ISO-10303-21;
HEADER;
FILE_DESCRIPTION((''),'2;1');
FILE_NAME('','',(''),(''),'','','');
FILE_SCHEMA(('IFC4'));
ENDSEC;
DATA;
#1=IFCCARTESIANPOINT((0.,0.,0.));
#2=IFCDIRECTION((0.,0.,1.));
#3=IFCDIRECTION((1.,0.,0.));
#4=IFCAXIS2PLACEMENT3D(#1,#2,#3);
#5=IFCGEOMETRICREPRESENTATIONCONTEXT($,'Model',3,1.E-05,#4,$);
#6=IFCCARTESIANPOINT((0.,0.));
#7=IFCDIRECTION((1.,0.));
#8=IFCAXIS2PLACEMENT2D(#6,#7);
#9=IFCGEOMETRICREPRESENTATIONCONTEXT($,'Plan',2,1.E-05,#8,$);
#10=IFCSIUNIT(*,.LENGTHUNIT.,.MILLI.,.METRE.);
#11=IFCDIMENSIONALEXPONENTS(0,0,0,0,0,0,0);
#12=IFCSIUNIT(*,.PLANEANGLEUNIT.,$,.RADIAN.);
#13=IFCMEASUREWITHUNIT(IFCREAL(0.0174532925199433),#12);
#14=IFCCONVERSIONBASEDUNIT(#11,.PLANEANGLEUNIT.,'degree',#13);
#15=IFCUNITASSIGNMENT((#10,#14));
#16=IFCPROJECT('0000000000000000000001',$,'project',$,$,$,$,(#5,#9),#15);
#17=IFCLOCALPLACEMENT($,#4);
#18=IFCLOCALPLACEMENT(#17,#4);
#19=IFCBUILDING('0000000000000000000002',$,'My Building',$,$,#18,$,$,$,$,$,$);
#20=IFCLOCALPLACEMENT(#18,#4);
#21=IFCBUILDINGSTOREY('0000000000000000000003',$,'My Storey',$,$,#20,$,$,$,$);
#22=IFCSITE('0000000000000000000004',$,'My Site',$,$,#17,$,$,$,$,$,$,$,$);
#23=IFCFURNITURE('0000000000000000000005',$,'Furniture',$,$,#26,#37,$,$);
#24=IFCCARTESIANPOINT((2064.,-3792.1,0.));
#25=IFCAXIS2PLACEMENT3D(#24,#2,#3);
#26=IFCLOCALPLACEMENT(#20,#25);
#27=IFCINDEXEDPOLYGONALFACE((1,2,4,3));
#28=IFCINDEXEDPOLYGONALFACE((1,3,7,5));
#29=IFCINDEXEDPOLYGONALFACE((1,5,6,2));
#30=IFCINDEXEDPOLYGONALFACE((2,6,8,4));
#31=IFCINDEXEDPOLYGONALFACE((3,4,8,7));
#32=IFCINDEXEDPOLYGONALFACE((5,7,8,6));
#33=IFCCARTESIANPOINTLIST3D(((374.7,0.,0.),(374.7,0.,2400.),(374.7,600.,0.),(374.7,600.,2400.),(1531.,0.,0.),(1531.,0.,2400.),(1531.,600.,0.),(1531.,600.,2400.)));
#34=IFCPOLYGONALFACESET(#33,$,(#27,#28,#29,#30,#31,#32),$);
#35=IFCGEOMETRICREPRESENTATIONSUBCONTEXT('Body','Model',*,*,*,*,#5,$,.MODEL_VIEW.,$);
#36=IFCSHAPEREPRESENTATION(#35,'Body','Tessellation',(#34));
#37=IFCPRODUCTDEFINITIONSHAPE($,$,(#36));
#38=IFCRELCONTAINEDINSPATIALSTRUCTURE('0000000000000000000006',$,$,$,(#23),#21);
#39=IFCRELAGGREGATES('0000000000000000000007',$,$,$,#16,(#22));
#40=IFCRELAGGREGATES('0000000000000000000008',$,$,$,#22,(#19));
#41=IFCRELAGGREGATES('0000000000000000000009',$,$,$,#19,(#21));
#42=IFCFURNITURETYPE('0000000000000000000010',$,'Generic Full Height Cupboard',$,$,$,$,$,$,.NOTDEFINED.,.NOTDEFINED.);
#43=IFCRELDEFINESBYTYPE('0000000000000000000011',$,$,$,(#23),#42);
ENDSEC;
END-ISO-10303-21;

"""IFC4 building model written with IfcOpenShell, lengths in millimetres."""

from ifc_helpers import new_model, entity, si_unit, converted_unit, frame, origin_with_axes, origin_2d_with_axis, place, context, subcontext, project, spatial, indexed_curve, outline, extrude, shape, source, transform, mapped, type_object, type_shapes, element, save


model = new_model("IFC4")

# Units and contexts
model_context = context("Model", 3, precision=1e-05, world=origin_with_axes())
plan_context = context("Plan", 2, precision=1e-05, world=origin_2d_with_axis())
body_context_1 = subcontext(model_context, "Body", "Model", "MODEL_VIEW")
body_context_2 = subcontext(plan_context, "Body", "Plan", "PLAN_VIEW")
ifc_project = project(units=[si_unit("LENGTHUNIT", "METRE", prefix="MILLI"), converted_unit("PLANEANGLEUNIT", "degree", entity("IfcReal", 0.0174532925199433), si_unit("PLANEANGLEUNIT", "RADIAN"), dimensions=[0, 0, 0, 0, 0, 0, 0])], contexts=[model_context, plan_context])

# Site, building, storey
site_placement = place(None, origin_with_axes())
site = spatial("IfcSite", under=ifc_project, at=site_placement, Name="My Site")
building_placement = place(site_placement, origin_with_axes())
building = spatial("IfcBuilding", under=site, at=building_placement, Name="My Building")
storey_placement = place(building_placement, origin_with_axes())
storey = spatial("IfcBuildingStorey", under=building, at=storey_placement, Name="My Storey")

# Furniture
furniture_type_1 = type_object("IfcFurnitureType", Name="Generic Full Height Cupboard", AssemblyPlace="NOTDEFINED", PredefinedType="NOTDEFINED")
shared_shape_1 = source(origin_with_axes(), body_context_1, "Body", "SolidModel", [
    extrude(outline(indexed_curve([(374.7, 0.0), (1531.0, 0.0), (1531.0, 600.0), (374.7, 600.0), (374.7, 0.0)])), origin_with_axes(), (0.0, 0.0, 1.0), 2400.0),
])
shared_shape_2 = source(origin_with_axes(), body_context_2, "Body", "Curve2D", [
    entity("IfcIndexedPolyCurve", entity("IfcCartesianPointList2D", [[0.0, 0.0], [600.0, 0.0], [600.0, 600.0], [0.0, 600.0]]), [entity("IfcLineIndex", [1, 2, 3, 4, 1])]),
])
type_shapes(furniture_type_1, [shared_shape_1, shared_shape_2])
furniture_1_placement = place(storey_placement, frame((2064.0, -3792.1, 0.0), z_axis=(0.0, 0.0, 1.0), x_axis=(1.0, 0.0, 0.0)))
element("IfcFurniture", 1, at=furniture_1_placement, inside=storey, type_object=furniture_type_1, Name="Furniture", shapes=[
    shape(body_context_1, "Body", "MappedRepresentation", [mapped(shared_shape_1, transform((0.0, 0.0, 0.0), x_axis=(1.0, 0.0, 0.0), y_axis=(0.0, 1.0, 0.0), z_axis=(0.0, 0.0, 1.0), scale=1.0))]),
    shape(body_context_2, "Body", "MappedRepresentation", [mapped(shared_shape_2, transform((0.0, 0.0, 0.0), x_axis=(1.0, 0.0, 0.0), y_axis=(0.0, 1.0, 0.0), z_axis=(0.0, 0.0, 1.0), scale=1.0))]),
])

save(model, "model.ifc")
